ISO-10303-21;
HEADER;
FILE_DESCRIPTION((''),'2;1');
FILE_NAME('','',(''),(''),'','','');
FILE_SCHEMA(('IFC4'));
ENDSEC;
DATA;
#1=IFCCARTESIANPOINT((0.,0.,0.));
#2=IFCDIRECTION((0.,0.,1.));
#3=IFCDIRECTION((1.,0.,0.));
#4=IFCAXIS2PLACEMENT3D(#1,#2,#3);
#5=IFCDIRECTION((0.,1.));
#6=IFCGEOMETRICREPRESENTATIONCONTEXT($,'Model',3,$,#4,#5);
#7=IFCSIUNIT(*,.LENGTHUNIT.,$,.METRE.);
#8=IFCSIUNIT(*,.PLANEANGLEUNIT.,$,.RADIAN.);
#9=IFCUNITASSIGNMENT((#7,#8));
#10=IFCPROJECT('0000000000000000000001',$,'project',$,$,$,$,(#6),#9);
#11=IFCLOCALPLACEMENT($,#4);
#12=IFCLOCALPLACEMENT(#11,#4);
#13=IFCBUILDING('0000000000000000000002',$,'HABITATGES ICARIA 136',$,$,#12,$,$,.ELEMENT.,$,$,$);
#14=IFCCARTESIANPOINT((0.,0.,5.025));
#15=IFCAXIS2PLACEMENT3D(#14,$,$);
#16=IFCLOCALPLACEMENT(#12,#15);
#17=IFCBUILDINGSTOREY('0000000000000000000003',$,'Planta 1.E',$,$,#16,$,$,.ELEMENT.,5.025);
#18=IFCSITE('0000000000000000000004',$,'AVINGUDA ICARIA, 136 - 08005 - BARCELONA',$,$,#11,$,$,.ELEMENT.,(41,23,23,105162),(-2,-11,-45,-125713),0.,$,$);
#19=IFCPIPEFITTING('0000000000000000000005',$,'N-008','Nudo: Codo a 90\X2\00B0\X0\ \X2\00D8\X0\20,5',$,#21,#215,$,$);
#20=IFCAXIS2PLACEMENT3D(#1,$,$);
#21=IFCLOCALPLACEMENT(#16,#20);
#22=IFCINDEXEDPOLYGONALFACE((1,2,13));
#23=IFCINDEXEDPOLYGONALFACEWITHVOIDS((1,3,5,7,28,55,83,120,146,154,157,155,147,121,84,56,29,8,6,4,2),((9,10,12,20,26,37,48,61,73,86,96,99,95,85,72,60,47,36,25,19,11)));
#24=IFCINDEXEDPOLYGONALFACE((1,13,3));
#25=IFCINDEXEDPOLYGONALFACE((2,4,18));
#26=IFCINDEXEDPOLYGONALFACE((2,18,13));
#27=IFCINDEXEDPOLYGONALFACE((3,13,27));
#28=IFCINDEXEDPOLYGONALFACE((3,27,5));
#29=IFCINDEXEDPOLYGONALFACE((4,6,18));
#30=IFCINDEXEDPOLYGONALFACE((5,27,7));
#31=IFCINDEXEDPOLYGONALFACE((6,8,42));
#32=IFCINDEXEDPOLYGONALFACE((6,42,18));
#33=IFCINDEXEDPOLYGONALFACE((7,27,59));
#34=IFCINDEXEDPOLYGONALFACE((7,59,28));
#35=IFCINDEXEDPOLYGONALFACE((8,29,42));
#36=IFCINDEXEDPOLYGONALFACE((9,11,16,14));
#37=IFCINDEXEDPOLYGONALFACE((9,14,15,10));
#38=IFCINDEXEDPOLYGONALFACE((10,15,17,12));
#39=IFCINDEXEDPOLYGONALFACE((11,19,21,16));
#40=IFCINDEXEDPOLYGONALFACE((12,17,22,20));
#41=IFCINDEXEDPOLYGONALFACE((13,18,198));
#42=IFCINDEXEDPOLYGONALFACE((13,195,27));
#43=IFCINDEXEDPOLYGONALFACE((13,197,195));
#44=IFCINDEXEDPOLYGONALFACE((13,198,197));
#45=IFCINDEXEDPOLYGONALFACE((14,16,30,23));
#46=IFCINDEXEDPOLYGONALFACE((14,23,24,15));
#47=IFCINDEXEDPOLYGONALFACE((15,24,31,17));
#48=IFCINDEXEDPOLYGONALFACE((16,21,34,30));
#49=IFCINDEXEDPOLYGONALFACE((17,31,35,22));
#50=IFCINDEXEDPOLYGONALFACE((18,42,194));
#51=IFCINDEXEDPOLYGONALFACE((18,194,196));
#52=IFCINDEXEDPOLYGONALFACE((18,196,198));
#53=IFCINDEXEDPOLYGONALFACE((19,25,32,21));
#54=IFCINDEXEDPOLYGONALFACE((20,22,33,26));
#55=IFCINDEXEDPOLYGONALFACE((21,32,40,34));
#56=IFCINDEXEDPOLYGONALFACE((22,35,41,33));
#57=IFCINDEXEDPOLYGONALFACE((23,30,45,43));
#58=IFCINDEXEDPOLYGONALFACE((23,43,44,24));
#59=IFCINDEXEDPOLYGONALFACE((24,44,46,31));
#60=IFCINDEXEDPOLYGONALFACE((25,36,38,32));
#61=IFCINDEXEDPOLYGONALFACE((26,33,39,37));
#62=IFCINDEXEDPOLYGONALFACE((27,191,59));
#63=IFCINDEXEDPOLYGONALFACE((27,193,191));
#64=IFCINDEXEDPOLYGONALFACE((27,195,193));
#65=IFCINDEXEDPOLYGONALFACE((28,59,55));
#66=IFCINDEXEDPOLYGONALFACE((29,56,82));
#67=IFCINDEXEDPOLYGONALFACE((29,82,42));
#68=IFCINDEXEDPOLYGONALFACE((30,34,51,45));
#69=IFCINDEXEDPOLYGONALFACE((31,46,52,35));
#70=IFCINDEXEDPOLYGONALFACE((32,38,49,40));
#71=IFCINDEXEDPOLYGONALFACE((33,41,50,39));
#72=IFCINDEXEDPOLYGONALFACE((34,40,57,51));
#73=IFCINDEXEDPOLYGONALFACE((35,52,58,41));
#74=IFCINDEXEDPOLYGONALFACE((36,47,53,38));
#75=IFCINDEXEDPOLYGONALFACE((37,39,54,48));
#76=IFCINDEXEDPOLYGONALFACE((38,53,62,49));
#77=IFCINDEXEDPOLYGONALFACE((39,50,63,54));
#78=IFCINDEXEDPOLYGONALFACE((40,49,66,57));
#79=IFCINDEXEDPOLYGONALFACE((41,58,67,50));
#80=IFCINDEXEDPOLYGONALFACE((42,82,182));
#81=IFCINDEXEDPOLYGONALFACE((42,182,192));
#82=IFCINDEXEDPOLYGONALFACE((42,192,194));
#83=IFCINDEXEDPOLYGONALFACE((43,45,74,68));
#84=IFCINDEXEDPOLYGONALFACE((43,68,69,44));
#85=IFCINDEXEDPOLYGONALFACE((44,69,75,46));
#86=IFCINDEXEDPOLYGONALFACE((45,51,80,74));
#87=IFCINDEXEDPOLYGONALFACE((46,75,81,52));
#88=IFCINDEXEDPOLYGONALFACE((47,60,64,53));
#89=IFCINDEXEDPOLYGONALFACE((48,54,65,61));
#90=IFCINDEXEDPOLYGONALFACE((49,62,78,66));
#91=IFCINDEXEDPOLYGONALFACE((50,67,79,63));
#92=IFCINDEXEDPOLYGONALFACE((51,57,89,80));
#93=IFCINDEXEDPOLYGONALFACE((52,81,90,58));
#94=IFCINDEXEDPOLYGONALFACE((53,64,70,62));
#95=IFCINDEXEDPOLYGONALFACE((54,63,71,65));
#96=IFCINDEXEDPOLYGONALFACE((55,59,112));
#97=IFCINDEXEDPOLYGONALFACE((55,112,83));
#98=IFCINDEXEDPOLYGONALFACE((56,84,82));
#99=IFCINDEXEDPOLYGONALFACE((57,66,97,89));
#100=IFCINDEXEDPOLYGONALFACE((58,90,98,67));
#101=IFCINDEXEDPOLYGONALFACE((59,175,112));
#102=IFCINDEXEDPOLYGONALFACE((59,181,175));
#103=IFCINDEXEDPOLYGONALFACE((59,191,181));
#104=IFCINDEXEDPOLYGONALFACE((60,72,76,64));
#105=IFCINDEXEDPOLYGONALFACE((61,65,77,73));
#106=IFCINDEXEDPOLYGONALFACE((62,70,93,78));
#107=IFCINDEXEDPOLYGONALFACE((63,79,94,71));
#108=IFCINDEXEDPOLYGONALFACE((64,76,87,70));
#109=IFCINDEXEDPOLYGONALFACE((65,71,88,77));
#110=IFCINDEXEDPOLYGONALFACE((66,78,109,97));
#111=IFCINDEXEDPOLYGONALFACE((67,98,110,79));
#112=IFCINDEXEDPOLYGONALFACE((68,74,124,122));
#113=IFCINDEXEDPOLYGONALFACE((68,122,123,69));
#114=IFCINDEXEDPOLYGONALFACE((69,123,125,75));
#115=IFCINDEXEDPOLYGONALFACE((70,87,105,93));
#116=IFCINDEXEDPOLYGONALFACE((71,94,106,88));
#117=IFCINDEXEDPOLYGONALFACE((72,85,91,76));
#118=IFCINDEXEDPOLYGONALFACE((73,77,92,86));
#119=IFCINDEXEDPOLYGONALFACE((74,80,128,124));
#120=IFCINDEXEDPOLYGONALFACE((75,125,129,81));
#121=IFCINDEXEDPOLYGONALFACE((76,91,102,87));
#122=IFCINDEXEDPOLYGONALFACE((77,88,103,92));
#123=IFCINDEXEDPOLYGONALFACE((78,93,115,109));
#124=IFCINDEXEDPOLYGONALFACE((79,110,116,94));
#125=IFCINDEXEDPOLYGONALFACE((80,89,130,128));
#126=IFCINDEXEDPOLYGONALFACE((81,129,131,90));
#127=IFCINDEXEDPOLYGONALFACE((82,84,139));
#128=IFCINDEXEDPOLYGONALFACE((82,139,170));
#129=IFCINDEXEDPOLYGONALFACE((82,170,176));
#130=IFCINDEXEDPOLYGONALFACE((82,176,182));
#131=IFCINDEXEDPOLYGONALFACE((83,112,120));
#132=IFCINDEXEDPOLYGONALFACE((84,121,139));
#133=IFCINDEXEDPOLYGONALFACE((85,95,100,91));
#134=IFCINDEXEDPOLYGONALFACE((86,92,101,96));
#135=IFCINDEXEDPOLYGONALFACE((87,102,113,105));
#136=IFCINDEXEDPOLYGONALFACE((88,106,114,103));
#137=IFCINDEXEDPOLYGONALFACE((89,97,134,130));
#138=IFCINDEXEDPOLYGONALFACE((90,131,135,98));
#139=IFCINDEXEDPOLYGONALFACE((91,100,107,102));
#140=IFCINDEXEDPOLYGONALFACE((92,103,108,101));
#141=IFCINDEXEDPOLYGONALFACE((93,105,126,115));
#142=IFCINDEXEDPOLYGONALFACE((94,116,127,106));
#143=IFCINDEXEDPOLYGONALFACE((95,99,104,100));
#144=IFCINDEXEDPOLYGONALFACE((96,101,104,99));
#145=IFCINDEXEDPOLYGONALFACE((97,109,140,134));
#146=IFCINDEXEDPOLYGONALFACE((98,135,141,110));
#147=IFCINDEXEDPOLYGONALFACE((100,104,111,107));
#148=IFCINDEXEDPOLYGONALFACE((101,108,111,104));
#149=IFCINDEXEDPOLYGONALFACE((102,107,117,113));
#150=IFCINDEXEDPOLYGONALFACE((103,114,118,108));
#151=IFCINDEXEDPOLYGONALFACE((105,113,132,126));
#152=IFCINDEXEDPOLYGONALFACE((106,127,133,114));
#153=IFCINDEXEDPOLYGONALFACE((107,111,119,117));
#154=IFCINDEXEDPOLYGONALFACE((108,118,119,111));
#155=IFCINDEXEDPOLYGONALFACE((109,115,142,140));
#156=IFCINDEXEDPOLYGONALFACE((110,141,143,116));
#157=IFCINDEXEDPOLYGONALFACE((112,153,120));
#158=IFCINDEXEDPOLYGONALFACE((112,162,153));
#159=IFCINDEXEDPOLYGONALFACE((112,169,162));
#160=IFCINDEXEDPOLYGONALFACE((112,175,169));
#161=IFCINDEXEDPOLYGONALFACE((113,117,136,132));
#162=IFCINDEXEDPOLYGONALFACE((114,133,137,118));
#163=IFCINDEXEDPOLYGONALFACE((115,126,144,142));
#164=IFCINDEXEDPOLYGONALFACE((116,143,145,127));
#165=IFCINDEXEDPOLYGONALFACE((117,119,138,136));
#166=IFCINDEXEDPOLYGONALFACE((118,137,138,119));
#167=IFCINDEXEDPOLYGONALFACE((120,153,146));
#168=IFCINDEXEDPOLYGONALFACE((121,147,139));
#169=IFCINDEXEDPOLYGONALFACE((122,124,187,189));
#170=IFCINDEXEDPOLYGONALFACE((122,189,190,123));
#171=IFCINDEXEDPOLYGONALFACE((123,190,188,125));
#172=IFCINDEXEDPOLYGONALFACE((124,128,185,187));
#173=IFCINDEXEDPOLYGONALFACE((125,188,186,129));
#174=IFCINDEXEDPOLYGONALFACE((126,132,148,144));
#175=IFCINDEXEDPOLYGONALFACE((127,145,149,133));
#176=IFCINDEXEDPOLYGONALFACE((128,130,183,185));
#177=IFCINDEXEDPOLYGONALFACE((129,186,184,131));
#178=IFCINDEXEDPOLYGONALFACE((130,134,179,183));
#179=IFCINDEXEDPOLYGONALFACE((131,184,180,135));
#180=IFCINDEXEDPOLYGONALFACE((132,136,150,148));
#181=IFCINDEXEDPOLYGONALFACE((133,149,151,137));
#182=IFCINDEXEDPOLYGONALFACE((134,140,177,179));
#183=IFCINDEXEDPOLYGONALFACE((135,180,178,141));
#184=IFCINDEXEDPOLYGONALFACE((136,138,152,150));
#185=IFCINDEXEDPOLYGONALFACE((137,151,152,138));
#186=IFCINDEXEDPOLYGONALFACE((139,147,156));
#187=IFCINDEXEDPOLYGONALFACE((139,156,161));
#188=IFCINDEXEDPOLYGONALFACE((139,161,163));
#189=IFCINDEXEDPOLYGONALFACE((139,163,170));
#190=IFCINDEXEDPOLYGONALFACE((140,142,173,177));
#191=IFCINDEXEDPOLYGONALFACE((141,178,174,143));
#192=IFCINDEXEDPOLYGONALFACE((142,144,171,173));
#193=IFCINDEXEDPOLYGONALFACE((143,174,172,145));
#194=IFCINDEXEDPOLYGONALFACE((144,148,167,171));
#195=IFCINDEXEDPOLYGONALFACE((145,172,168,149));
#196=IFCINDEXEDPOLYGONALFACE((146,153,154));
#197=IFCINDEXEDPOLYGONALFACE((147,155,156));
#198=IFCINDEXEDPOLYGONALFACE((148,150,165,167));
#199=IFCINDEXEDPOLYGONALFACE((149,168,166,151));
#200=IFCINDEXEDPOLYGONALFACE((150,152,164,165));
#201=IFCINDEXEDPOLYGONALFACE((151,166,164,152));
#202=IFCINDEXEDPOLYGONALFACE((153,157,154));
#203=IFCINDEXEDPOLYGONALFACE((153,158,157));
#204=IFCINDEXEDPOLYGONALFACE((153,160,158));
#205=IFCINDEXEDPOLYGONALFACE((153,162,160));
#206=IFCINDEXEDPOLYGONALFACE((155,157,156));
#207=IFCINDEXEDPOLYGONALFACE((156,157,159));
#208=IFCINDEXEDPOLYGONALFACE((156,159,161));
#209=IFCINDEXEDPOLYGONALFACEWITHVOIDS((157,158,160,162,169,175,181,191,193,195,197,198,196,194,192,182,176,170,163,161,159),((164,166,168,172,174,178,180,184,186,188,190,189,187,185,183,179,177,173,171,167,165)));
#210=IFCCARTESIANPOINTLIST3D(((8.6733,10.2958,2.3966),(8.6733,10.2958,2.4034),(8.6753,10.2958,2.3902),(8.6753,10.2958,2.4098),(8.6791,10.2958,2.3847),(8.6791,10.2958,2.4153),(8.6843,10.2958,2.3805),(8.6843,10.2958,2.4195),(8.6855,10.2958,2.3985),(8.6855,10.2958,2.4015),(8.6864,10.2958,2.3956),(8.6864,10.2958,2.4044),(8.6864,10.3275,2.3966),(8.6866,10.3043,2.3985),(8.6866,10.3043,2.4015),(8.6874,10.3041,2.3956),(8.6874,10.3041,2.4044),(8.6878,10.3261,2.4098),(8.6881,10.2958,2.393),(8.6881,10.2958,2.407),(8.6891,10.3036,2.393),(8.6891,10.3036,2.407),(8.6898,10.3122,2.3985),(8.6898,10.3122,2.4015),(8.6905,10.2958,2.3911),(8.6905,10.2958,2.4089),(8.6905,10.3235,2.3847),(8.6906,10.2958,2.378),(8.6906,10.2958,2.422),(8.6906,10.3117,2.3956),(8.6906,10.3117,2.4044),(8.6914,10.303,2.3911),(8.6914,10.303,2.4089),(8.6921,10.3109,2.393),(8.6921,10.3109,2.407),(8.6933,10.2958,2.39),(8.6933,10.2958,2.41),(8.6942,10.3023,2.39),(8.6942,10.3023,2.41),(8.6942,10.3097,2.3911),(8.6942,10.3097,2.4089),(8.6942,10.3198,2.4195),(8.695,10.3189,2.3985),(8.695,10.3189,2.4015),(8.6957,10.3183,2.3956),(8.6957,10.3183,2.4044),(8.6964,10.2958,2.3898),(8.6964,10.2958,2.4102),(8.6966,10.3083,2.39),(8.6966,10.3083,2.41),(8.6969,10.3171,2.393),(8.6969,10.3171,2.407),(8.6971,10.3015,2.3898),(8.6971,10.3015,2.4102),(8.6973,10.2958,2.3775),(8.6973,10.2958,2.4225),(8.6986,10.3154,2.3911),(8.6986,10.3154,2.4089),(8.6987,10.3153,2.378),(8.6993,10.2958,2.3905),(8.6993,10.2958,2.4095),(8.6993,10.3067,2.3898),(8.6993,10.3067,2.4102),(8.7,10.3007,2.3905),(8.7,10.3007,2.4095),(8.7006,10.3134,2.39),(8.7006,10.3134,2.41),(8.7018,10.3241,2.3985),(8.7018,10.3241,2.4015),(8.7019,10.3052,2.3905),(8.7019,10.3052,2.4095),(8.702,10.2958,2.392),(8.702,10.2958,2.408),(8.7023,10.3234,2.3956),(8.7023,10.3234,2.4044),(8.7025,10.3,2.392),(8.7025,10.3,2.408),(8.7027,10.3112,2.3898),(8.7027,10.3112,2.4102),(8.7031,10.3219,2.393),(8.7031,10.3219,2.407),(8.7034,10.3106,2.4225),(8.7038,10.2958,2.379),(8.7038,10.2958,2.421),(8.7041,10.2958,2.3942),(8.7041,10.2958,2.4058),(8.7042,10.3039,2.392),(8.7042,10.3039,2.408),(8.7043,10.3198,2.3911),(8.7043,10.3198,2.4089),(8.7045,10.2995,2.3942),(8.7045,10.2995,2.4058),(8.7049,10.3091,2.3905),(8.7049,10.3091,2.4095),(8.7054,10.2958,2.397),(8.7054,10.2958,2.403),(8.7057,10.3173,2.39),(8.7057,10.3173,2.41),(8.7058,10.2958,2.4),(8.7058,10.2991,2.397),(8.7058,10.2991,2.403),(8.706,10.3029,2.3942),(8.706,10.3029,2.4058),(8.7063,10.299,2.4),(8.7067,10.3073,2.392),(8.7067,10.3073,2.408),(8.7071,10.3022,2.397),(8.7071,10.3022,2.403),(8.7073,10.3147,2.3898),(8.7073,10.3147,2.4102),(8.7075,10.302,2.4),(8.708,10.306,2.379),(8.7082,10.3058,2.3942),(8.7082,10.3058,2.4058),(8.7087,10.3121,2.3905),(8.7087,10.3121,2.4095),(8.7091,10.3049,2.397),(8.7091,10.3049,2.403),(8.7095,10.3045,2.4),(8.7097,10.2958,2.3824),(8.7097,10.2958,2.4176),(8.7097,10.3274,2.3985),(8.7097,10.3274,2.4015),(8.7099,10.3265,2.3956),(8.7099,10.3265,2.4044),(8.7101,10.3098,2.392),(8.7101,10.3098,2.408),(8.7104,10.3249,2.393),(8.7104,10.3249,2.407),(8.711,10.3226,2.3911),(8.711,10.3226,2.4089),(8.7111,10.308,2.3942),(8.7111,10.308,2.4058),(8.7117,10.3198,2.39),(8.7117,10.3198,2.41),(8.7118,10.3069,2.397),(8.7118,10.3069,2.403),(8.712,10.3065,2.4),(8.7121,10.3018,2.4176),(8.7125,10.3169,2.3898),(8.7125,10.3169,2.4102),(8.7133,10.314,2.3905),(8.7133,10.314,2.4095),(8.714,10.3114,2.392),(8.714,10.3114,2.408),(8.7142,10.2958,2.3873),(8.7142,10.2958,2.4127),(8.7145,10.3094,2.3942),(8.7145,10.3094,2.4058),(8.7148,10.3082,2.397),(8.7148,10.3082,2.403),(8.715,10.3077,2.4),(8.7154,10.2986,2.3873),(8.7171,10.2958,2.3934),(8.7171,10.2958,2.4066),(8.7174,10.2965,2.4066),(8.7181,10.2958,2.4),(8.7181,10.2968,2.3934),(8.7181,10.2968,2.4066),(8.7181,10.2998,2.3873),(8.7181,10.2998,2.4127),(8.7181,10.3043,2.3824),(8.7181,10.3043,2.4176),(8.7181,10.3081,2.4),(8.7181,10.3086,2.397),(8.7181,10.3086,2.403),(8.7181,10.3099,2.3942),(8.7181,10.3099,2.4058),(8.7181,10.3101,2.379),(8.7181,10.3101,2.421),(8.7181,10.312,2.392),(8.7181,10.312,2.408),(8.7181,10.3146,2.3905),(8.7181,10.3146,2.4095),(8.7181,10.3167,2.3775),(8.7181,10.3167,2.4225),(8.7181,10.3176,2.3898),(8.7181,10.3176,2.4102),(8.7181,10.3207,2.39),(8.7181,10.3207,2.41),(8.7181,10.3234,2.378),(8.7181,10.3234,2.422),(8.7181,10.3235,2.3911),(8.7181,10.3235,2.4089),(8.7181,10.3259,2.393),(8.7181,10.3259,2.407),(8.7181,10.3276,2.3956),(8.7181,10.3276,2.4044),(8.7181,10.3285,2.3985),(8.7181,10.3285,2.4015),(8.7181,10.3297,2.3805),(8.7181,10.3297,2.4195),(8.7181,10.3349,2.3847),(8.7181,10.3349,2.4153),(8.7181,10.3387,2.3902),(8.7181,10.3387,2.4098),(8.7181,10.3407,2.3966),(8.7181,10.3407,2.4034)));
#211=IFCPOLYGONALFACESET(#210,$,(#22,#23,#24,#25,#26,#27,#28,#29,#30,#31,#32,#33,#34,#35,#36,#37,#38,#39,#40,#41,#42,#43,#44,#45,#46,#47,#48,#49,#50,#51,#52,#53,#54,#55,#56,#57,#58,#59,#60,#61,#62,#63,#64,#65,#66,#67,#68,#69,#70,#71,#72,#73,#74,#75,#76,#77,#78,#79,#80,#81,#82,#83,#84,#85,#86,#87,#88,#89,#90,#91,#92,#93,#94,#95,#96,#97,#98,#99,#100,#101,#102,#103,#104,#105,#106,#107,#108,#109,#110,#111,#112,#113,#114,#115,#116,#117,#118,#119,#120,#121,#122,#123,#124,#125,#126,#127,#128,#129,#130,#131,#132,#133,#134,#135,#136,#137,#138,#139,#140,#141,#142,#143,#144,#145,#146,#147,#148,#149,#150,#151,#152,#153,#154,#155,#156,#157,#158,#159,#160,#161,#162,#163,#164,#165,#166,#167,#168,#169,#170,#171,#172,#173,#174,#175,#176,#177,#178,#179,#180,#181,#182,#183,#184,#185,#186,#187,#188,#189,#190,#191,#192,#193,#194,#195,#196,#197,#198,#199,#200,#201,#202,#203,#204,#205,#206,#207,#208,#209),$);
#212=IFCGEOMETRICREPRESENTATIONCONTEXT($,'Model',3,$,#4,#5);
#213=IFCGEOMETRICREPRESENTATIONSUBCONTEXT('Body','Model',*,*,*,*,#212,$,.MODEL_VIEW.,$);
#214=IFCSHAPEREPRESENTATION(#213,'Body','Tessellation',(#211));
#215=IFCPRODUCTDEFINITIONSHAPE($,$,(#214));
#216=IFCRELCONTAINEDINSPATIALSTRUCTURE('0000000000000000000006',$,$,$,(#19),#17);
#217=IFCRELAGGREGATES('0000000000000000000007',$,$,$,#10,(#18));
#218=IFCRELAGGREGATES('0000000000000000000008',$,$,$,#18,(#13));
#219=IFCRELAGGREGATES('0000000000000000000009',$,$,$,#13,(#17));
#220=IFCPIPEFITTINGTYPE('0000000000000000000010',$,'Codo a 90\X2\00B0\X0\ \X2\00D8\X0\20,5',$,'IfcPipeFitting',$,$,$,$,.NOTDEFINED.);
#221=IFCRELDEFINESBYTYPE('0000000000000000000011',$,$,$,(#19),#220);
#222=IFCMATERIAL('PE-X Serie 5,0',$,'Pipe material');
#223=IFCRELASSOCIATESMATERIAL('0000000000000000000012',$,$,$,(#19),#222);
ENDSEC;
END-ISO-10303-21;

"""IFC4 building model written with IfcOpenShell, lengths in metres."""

from ifc_helpers import new_model, entity, si_unit, direction, frame, origin_with_axes, place, context, subcontext, project, spatial, source, transform, mapped, material, type_object, element, save


model = new_model("IFC4")

# Units and contexts
model_context_1 = context("Model", 3, world=origin_with_axes(), true_north=direction((0.0, 1.0)))
model_context_2 = context("Model", 3, world=origin_with_axes(), true_north=direction((0.0, 1.0)))
body_context_1 = subcontext(model_context_2, "Body", "Model", "MODEL_VIEW")
ifc_project = project(units=[si_unit("LENGTHUNIT", "METRE"), si_unit("PLANEANGLEUNIT", "RADIAN")], contexts=[model_context_1])

# Site, building, storey
site_placement = place(None, origin_with_axes())
site = spatial("IfcSite", under=ifc_project, at=site_placement, Name="AVINGUDA ICARIA, 136 - 08005 - BARCELONA", CompositionType="ELEMENT", RefLatitude=(41, 23, 23, 105162), RefLongitude=(-2, -11, -45, -125713), RefElevation=0.0)
building_placement = place(site_placement, origin_with_axes())
building = spatial("IfcBuilding", under=site, at=building_placement, Name="HABITATGES ICARIA 136", CompositionType="ELEMENT")
storey_placement = place(building_placement, frame((0.0, 0.0, 5.025)))
storey = spatial("IfcBuildingStorey", under=building, at=storey_placement, Name="Planta 1.E", CompositionType="ELEMENT", Elevation=5.025)

# Shared definitions
ifc_material_1 = material(Name="PE-X Serie 5,0", Category="Pipe material")
placement_1 = place(None, origin_with_axes())
placement_2 = place(placement_1, origin_with_axes())
placement_3 = place(placement_2, frame((0.0, 0.0, 5.025)))

# Pipe fitting
pipe_fitting_type_1 = type_object("IfcPipeFittingType", Name="Codo a 90° Ø20,5", ApplicableOccurrence="IfcPipeFitting", PredefinedType="NOTDEFINED")
shared_shape_1 = source(origin_with_axes(), body_context_1, "Body", "SweptSolid", [
    entity("IfcRevolvedAreaSolid", entity("IfcCircleHollowProfileDef", "AREA", None, entity("IfcAxis2Placement2D", entity("IfcCartesianPoint", [0.0, 0.0]), entity("IfcDirection", [1.0, 0.0])), 0.0226, 0.0123), entity("IfcAxis2Placement3D", entity("IfcCartesianPoint", [0.0226, 0.0, 0.0]), entity("IfcDirection", [-1.0, 0.0, 0.0]), entity("IfcDirection", [0.0, -1.0, 0.0])), entity("IfcAxis1Placement", entity("IfcCartesianPoint", [0.0226, 0.0, 0.0]), entity("IfcDirection", [0.0, 1.0, 0.0])), 1.570796),
])
pipe_fitting_1_placement = place(placement_3, origin_with_axes())
element("IfcPipeFitting", 1, at=pipe_fitting_1_placement, inside=storey, type_object=pipe_fitting_type_1, material=ifc_material_1, Name="N-008", Description="Nudo: Codo a 90° Ø20,5", context=body_context_1, shape_type="MappedRepresentation", body=[
    mapped(shared_shape_1, transform((8.6956, 10.3184, 2.4), x_axis=(0.0, -1.0, 0.0), y_axis=(-1.0, 0.0, 0.0), z_axis=(0.0, 0.0, -1.0), scale=1.0)),
])

save(model, "model.ifc")
